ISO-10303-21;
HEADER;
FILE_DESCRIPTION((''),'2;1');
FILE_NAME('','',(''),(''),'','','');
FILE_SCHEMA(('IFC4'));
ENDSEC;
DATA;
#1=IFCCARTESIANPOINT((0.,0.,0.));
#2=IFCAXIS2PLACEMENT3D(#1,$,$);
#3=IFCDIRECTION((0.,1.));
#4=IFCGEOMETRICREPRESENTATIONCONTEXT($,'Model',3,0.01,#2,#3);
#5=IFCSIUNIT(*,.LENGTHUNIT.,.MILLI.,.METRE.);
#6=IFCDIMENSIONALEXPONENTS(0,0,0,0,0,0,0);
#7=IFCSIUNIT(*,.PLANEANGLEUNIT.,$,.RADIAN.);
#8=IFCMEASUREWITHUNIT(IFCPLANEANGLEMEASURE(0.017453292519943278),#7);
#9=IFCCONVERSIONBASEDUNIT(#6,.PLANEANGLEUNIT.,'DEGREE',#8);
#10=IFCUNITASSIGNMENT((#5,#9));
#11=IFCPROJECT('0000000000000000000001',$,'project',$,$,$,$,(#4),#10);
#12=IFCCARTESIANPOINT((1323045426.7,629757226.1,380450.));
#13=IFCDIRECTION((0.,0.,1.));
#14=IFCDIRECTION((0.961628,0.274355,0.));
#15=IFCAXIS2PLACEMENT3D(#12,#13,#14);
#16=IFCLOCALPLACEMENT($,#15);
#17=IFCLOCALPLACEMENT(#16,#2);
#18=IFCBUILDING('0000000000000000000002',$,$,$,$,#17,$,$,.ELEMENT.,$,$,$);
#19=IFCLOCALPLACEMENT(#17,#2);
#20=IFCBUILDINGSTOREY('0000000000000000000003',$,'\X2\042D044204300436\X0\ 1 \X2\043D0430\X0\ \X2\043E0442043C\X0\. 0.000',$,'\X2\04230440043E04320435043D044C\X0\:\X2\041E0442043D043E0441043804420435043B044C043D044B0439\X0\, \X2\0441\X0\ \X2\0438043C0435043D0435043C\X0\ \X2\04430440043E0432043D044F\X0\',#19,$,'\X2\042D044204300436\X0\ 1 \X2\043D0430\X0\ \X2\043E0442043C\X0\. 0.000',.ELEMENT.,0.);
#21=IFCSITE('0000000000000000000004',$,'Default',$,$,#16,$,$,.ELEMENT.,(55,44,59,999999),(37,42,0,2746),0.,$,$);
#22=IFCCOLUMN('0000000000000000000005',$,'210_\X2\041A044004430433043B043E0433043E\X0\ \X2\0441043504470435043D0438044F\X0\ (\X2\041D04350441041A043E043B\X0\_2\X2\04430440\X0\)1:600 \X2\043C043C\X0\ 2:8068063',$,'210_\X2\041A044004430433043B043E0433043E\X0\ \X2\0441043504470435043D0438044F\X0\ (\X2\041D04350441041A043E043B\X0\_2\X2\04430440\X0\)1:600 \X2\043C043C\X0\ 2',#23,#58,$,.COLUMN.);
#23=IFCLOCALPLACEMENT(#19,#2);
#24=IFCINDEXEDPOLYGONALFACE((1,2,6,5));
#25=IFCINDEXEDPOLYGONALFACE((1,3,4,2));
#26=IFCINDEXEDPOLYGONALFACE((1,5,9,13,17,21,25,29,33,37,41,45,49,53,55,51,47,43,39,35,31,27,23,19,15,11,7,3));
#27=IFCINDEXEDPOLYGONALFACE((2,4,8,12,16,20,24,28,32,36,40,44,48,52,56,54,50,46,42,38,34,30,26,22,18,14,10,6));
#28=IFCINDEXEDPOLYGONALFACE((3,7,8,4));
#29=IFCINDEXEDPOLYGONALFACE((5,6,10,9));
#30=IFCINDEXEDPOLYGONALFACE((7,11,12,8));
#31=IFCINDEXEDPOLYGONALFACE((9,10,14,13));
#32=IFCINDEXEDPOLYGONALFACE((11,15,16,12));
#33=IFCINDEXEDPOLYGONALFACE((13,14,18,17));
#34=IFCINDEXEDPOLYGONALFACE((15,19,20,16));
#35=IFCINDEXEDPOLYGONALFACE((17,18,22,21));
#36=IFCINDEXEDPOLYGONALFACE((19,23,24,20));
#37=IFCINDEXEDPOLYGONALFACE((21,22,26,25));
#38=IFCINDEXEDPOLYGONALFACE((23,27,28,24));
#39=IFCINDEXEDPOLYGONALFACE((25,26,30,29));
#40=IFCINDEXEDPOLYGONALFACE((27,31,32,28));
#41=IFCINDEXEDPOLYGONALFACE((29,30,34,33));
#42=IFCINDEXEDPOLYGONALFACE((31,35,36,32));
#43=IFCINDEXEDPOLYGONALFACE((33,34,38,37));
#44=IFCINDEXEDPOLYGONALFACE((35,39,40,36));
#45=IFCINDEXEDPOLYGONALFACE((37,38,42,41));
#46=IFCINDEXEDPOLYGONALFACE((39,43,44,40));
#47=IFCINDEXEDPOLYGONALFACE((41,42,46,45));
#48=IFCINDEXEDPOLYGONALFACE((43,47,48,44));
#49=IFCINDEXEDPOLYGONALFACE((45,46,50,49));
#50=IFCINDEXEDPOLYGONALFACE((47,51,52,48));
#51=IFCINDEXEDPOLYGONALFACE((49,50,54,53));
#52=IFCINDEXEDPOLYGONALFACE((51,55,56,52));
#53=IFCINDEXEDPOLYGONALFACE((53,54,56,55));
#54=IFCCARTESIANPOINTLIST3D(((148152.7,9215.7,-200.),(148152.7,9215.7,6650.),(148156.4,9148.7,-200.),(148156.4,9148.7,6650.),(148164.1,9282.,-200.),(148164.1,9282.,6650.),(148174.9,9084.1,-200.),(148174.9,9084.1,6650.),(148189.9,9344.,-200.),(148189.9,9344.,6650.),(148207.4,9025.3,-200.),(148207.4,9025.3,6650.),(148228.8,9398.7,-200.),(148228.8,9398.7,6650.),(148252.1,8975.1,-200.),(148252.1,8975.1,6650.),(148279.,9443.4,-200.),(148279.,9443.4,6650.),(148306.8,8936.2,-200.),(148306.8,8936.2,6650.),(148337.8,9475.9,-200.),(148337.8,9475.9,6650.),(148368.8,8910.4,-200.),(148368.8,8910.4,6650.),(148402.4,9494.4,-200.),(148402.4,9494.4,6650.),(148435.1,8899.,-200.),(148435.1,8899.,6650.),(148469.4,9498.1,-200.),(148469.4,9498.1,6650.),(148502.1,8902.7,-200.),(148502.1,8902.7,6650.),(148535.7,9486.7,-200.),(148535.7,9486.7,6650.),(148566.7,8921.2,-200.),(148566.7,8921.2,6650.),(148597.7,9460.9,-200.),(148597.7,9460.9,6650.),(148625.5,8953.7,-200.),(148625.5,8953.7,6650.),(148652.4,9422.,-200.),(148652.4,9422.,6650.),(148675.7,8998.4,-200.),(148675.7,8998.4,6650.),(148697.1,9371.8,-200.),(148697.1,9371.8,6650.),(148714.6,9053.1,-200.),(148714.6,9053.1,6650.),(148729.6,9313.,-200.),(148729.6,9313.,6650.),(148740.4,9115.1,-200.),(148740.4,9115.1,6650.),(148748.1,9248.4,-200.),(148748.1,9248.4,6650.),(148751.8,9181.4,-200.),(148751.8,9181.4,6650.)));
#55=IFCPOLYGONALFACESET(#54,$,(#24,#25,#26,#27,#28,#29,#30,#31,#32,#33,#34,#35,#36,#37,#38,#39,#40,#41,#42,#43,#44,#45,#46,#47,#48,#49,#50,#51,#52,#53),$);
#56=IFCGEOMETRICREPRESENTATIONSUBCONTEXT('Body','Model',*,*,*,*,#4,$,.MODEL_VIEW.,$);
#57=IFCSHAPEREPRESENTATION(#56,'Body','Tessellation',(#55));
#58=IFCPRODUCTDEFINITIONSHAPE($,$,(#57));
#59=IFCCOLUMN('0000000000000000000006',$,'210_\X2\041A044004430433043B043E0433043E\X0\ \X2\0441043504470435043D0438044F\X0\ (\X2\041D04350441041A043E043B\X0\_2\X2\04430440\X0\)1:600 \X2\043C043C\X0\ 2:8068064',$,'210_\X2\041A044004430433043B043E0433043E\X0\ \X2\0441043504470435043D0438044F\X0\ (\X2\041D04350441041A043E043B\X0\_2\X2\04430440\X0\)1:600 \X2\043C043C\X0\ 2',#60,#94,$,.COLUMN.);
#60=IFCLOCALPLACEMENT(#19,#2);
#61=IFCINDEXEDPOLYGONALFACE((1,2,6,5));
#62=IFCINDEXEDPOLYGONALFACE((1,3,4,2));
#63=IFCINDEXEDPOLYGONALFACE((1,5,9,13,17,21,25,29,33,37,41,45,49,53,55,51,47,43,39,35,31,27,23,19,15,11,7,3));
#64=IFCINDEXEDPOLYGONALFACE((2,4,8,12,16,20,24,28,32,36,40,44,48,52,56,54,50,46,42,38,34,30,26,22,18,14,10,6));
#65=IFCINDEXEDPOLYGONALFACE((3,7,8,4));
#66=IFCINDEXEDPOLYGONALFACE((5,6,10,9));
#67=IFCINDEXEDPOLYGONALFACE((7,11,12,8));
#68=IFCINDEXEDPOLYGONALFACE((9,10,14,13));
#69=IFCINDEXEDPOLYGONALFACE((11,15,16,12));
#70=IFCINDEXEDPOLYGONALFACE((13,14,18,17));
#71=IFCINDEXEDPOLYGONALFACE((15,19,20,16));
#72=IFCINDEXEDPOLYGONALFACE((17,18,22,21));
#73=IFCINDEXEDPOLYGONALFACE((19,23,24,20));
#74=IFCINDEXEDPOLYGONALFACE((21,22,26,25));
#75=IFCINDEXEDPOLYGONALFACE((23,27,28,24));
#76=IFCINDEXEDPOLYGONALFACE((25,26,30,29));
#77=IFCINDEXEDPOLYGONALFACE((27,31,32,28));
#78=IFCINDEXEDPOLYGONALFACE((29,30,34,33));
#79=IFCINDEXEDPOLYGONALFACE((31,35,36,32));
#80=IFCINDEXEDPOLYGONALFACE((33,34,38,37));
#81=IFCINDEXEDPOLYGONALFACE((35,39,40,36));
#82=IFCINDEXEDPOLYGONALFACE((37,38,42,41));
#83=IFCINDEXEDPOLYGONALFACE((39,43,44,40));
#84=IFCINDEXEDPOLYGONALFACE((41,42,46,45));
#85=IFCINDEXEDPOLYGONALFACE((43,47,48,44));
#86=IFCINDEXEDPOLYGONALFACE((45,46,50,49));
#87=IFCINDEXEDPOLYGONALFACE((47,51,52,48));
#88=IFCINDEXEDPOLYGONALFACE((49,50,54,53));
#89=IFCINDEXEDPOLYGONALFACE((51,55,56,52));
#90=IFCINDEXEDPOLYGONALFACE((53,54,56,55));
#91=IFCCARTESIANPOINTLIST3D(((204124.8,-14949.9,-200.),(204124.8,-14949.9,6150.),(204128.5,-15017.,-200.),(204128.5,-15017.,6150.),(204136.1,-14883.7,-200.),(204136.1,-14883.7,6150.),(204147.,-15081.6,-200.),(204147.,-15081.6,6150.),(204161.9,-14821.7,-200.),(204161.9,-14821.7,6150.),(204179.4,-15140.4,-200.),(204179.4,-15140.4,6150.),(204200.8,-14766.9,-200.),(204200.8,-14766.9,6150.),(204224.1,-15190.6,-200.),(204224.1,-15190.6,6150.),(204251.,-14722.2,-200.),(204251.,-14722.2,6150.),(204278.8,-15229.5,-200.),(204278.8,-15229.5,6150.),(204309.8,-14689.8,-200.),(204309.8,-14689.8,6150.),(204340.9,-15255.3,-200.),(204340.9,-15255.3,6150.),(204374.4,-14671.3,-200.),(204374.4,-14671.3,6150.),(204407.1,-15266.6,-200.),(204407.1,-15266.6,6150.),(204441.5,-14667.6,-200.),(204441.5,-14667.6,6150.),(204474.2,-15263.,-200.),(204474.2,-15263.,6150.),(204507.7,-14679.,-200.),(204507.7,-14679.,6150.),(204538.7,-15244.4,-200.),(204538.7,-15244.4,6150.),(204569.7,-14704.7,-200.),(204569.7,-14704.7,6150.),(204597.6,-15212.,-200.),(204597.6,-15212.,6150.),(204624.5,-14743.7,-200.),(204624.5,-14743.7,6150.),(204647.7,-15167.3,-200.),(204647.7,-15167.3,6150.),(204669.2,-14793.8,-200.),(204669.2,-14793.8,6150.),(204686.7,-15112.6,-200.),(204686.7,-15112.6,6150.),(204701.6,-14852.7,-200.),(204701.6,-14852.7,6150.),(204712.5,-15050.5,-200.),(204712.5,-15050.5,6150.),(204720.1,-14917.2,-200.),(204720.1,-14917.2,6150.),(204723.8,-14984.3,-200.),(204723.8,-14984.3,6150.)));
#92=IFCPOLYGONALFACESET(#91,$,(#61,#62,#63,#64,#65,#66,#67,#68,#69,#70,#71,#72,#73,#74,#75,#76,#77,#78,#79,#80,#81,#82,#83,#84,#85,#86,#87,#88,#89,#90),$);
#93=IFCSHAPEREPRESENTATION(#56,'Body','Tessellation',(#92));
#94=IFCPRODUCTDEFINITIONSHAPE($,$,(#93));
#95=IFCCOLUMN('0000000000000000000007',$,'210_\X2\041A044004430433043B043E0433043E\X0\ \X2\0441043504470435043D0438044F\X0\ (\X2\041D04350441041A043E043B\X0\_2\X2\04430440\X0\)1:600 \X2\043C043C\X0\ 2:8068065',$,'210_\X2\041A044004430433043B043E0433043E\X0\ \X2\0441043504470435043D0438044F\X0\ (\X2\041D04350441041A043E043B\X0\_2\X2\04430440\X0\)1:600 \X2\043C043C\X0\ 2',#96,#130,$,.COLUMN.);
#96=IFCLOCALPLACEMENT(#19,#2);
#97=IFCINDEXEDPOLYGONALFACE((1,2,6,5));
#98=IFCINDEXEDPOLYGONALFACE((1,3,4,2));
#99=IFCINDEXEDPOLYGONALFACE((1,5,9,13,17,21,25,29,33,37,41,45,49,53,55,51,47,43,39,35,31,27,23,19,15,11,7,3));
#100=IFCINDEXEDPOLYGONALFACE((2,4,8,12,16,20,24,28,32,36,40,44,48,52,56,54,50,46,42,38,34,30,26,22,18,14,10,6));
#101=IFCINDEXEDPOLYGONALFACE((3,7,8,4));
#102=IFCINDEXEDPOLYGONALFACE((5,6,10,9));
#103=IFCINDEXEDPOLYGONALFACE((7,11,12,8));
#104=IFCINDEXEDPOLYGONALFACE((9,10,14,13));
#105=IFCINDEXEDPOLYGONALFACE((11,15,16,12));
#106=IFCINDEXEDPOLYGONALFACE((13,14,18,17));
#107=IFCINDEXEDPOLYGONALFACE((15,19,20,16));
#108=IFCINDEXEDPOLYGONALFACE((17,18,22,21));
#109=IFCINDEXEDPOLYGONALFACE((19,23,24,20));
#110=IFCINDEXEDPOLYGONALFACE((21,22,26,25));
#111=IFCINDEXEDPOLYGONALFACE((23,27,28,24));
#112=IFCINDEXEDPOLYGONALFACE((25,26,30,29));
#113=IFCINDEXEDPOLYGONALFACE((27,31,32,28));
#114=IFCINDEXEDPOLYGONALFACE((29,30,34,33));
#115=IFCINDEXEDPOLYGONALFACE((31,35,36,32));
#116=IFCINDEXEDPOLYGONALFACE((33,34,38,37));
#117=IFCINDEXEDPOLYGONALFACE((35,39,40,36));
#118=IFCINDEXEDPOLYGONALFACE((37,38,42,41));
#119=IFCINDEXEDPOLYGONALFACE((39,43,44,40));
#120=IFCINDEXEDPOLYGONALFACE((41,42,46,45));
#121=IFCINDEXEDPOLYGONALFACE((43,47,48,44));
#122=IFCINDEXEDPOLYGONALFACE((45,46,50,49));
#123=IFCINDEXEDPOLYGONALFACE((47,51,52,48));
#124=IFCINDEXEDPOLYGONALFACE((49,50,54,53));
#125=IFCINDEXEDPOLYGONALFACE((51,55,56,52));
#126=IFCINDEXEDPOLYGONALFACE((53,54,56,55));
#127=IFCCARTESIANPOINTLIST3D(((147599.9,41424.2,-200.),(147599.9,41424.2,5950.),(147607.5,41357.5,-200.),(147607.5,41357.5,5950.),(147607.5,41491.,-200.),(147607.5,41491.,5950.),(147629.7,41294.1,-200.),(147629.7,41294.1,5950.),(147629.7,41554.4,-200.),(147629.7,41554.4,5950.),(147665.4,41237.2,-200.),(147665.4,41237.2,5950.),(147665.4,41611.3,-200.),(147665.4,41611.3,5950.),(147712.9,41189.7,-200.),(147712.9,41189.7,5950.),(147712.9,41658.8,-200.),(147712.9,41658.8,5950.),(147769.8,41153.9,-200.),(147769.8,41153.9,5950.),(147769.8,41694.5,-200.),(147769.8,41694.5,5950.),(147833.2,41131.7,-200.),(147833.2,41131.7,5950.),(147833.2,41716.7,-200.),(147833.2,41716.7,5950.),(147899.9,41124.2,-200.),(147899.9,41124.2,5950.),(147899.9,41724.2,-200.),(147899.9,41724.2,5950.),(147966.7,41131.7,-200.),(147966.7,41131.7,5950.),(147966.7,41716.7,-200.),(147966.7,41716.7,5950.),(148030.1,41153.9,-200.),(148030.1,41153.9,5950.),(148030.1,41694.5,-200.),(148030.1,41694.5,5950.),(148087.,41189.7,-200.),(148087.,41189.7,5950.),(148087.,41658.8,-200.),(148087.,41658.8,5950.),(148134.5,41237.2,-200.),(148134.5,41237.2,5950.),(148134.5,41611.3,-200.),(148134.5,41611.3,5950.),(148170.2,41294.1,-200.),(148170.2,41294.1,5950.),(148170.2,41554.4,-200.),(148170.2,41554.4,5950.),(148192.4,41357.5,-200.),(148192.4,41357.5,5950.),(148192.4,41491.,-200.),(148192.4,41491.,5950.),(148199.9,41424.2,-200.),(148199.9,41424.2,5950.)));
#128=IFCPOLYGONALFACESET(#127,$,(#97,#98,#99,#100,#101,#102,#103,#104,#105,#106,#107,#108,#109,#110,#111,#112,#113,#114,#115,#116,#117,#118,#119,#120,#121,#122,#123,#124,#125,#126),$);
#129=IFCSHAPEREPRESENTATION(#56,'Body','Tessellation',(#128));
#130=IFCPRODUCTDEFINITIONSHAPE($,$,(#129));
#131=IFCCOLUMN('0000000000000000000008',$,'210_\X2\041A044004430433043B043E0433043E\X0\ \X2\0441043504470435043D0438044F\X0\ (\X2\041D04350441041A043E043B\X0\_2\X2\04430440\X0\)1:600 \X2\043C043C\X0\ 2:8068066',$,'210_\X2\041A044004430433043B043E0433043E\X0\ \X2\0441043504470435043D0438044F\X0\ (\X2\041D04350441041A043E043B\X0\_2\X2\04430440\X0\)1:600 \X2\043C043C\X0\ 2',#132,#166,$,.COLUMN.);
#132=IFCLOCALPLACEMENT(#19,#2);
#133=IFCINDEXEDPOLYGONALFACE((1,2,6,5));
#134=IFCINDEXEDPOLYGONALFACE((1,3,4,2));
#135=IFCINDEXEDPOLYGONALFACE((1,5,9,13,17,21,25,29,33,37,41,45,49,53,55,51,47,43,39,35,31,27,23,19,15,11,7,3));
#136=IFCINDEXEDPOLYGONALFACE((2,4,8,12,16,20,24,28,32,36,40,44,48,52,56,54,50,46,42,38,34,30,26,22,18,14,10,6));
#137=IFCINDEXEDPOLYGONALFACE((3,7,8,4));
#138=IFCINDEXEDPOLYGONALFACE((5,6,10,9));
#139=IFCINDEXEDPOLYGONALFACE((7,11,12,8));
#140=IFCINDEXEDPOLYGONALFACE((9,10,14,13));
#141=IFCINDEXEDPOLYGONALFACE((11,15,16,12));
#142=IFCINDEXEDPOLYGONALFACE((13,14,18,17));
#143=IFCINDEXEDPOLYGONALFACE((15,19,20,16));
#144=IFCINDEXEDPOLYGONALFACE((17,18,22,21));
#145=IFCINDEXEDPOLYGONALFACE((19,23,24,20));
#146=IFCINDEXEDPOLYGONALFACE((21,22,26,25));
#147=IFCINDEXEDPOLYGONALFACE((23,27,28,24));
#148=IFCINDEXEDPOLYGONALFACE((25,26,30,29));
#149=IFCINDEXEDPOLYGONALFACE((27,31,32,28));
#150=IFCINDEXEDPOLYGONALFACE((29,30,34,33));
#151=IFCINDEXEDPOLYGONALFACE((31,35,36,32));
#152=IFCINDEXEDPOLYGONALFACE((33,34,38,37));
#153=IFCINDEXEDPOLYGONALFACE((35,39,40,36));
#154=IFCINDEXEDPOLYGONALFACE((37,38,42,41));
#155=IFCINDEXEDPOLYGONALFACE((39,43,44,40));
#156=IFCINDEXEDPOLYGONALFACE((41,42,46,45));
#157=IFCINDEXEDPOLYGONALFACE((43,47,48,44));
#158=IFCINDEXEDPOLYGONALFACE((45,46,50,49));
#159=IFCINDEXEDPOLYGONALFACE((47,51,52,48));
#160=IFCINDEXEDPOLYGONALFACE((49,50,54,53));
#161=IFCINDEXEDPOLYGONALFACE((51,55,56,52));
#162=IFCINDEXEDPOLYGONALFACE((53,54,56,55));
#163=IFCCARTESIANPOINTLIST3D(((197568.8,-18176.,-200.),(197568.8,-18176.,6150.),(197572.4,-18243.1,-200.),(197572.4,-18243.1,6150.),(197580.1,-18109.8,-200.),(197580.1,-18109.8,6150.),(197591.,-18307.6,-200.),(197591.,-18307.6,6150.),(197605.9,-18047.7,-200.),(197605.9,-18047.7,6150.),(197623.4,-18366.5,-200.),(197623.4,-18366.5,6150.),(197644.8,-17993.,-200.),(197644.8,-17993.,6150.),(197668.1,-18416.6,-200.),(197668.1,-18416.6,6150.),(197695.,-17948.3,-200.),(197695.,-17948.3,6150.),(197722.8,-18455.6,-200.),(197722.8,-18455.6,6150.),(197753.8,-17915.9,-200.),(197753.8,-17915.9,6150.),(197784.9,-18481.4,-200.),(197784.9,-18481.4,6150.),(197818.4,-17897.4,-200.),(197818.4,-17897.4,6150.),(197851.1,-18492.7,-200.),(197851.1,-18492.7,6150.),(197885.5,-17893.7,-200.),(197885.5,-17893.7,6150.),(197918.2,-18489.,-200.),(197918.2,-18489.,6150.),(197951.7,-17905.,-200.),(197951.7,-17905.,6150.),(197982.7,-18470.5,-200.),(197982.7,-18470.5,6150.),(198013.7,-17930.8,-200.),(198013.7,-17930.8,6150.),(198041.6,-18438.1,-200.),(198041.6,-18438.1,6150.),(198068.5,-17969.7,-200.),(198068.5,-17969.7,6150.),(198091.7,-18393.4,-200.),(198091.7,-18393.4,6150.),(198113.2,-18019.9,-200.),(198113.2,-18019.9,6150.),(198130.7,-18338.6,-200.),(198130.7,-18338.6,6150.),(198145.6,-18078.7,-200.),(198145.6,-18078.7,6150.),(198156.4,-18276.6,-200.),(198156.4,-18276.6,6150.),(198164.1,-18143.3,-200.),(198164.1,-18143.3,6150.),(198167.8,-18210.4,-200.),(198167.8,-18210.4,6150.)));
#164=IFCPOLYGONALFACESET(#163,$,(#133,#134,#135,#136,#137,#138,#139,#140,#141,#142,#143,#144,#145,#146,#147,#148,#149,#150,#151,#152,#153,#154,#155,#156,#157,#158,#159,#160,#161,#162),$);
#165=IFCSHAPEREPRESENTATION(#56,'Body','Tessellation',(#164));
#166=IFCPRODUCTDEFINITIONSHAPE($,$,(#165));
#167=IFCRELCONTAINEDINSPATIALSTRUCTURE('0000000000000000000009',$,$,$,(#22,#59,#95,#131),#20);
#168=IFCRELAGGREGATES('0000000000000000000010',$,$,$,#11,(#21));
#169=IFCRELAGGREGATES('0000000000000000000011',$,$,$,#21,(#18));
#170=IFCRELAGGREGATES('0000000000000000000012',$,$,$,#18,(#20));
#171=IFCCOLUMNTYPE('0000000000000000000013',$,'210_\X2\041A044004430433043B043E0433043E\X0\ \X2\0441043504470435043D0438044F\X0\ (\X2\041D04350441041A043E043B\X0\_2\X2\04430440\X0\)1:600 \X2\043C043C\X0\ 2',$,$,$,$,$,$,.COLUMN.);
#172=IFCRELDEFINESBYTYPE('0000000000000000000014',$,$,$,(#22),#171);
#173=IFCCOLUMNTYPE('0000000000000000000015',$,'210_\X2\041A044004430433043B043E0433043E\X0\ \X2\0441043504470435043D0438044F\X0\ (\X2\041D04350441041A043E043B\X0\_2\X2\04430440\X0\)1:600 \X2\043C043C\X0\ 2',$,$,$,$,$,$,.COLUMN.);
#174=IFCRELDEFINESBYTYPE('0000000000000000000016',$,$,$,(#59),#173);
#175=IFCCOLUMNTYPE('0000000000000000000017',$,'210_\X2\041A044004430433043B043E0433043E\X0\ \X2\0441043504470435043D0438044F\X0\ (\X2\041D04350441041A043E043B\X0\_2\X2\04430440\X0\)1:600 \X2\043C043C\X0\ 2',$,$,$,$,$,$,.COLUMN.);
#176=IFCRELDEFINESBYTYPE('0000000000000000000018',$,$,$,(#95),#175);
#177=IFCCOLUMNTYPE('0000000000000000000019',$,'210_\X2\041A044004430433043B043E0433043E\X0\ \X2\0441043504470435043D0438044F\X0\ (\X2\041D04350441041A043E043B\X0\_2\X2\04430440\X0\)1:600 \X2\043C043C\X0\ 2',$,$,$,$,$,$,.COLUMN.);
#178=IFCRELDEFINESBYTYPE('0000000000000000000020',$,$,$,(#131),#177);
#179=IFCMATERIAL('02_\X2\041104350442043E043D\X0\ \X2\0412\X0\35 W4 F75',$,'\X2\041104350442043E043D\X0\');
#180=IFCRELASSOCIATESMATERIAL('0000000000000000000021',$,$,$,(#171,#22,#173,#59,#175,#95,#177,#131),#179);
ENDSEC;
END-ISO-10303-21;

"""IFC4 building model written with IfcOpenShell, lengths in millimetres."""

from ifc_helpers import new_model, entity, si_unit, converted_unit, direction, frame, origin, place, context, subcontext, project, spatial, arc, indexed_curve, outline, extrude, source, transform, mapped, material, type_object, type_shapes, element, save


model = new_model("IFC4")

# Units and contexts
model_context = context("Model", 3, precision=0.01, world=origin(), true_north=direction((0.0, 1.0)))
body_context = subcontext(model_context, "Body", "Model", "MODEL_VIEW")
ifc_project = project(units=[si_unit("LENGTHUNIT", "METRE", prefix="MILLI"), converted_unit("PLANEANGLEUNIT", "DEGREE", entity("IfcPlaneAngleMeasure", 0.017453292519943278), si_unit("PLANEANGLEUNIT", "RADIAN"), dimensions=[0, 0, 0, 0, 0, 0, 0])], contexts=[model_context])

# Site, building, storey
site_placement = place(None, frame((1323045426.7, 629757226.1, 380450.0), z_axis=(0.0, 0.0, 1.0), x_axis=(0.961628, 0.274355, 0.0)))
site = spatial("IfcSite", under=ifc_project, at=site_placement, Name="Default", CompositionType="ELEMENT", RefLatitude=(55, 44, 59, 999999), RefLongitude=(37, 42, 0, 2746), RefElevation=0.0)
building_placement = place(site_placement, origin())
building = spatial("IfcBuilding", under=site, at=building_placement, CompositionType="ELEMENT")
storey_placement = place(building_placement, origin())
storey = spatial("IfcBuildingStorey", under=building, at=storey_placement, Name="Этаж 1 на отм. 0.000", ObjectType="Уровень:Относительный, с именем уровня", LongName="Этаж 1 на отм. 0.000", CompositionType="ELEMENT", Elevation=0.0)

# Columns
ifc_material = material(Name="02_Бетон В35 W4 F75", Category="Бетон")
column_type_1 = type_object("IfcColumnType", Name="210_Круглого сечения (НесКол_2ур)1:600 мм 2", PredefinedType="COLUMN", material=ifc_material)
shared_shape_1 = source(origin(), body_context, "Body", "SweptSolid", [
    extrude(outline(indexed_curve([(-300.0, 0.0), (0.0, -300.0), (300.0, 0.0), (0.0, 300.0)], segments=[arc(1, 2, 3), arc(3, 4, 1)], self_intersect=False)), frame((148452.3, 9198.6, -200.0), z_axis=(0.0, 0.0, 1.0), x_axis=(0.87462, -0.48481, 0.0)), (0.0, 0.0, 1.0), 6850.0),
])
type_shapes(column_type_1, [shared_shape_1])
column_1_placement = place(storey_placement, origin())
element("IfcColumn", 1, at=column_1_placement, inside=storey, type_object=column_type_1, material=ifc_material, Name="210_Круглого сечения (НесКол_2ур)1:600 мм 2:8068063", ObjectType="210_Круглого сечения (НесКол_2ур)1:600 мм 2", PredefinedType="COLUMN", context=body_context, shape_type="MappedRepresentation", body=[
    mapped(shared_shape_1, transform((0.0, 0.0, 0.0), scale=1.0)),
])
column_type_2 = type_object("IfcColumnType", Name="210_Круглого сечения (НесКол_2ур)1:600 мм 2", PredefinedType="COLUMN", material=ifc_material)
shared_shape_2 = source(origin(), body_context, "Body", "SweptSolid", [
    extrude(outline(indexed_curve([(-300.0, 0.0), (0.0, -300.0), (300.0, 0.0), (0.0, 300.0)], segments=[arc(1, 2, 3), arc(3, 4, 1)], self_intersect=False)), frame((204424.3, -14967.1, -200.0), z_axis=(0.0, 0.0, 1.0), x_axis=(0.87462, -0.48481, 0.0)), (0.0, 0.0, 1.0), 6350.0),
])
type_shapes(column_type_2, [shared_shape_2])
column_2_placement = place(storey_placement, origin())
element("IfcColumn", 2, at=column_2_placement, inside=storey, type_object=column_type_2, material=ifc_material, Name="210_Круглого сечения (НесКол_2ур)1:600 мм 2:8068064", ObjectType="210_Круглого сечения (НесКол_2ур)1:600 мм 2", PredefinedType="COLUMN", context=body_context, shape_type="MappedRepresentation", body=[
    mapped(shared_shape_2, transform((0.0, 0.0, 0.0), scale=1.0)),
])
column_type_3 = type_object("IfcColumnType", Name="210_Круглого сечения (НесКол_2ур)1:600 мм 2", PredefinedType="COLUMN", material=ifc_material)
shared_shape_3 = source(origin(), body_context, "Body", "SweptSolid", [
    extrude(outline(indexed_curve([(-300.0, 0.0), (0.0, -300.0), (300.0, 0.0), (0.0, 300.0)], segments=[arc(1, 2, 3), arc(3, 4, 1)], self_intersect=False)), frame((147899.9, 41424.2, -200.0), z_axis=(0.0, 0.0, 1.0), x_axis=(0.0, -1.0, 0.0)), (0.0, 0.0, 1.0), 6150.0),
])
type_shapes(column_type_3, [shared_shape_3])
column_3_placement = place(storey_placement, origin())
element("IfcColumn", 3, at=column_3_placement, inside=storey, type_object=column_type_3, material=ifc_material, Name="210_Круглого сечения (НесКол_2ур)1:600 мм 2:8068065", ObjectType="210_Круглого сечения (НесКол_2ур)1:600 мм 2", PredefinedType="COLUMN", context=body_context, shape_type="MappedRepresentation", body=[
    mapped(shared_shape_3, transform((0.0, 0.0, 0.0), scale=1.0)),
])
column_type_4 = type_object("IfcColumnType", Name="210_Круглого сечения (НесКол_2ур)1:600 мм 2", PredefinedType="COLUMN", material=ifc_material)
shared_shape_4 = source(origin(), body_context, "Body", "SweptSolid", [
    extrude(outline(indexed_curve([(-300.0, 0.0), (0.0, -300.0), (300.0, 0.0), (0.0, 300.0)], segments=[arc(1, 2, 3), arc(3, 4, 1)], self_intersect=False)), frame((197868.3, -18193.2, -200.0), z_axis=(0.0, 0.0, 1.0), x_axis=(0.48481, 0.87462, 0.0)), (0.0, 0.0, 1.0), 6350.0),
])
type_shapes(column_type_4, [shared_shape_4])
column_4_placement = place(storey_placement, origin())
element("IfcColumn", 4, at=column_4_placement, inside=storey, type_object=column_type_4, material=ifc_material, Name="210_Круглого сечения (НесКол_2ур)1:600 мм 2:8068066", ObjectType="210_Круглого сечения (НесКол_2ур)1:600 мм 2", PredefinedType="COLUMN", context=body_context, shape_type="MappedRepresentation", body=[
    mapped(shared_shape_4, transform((0.0, 0.0, 0.0), scale=1.0)),
])

save(model, "model.ifc")
